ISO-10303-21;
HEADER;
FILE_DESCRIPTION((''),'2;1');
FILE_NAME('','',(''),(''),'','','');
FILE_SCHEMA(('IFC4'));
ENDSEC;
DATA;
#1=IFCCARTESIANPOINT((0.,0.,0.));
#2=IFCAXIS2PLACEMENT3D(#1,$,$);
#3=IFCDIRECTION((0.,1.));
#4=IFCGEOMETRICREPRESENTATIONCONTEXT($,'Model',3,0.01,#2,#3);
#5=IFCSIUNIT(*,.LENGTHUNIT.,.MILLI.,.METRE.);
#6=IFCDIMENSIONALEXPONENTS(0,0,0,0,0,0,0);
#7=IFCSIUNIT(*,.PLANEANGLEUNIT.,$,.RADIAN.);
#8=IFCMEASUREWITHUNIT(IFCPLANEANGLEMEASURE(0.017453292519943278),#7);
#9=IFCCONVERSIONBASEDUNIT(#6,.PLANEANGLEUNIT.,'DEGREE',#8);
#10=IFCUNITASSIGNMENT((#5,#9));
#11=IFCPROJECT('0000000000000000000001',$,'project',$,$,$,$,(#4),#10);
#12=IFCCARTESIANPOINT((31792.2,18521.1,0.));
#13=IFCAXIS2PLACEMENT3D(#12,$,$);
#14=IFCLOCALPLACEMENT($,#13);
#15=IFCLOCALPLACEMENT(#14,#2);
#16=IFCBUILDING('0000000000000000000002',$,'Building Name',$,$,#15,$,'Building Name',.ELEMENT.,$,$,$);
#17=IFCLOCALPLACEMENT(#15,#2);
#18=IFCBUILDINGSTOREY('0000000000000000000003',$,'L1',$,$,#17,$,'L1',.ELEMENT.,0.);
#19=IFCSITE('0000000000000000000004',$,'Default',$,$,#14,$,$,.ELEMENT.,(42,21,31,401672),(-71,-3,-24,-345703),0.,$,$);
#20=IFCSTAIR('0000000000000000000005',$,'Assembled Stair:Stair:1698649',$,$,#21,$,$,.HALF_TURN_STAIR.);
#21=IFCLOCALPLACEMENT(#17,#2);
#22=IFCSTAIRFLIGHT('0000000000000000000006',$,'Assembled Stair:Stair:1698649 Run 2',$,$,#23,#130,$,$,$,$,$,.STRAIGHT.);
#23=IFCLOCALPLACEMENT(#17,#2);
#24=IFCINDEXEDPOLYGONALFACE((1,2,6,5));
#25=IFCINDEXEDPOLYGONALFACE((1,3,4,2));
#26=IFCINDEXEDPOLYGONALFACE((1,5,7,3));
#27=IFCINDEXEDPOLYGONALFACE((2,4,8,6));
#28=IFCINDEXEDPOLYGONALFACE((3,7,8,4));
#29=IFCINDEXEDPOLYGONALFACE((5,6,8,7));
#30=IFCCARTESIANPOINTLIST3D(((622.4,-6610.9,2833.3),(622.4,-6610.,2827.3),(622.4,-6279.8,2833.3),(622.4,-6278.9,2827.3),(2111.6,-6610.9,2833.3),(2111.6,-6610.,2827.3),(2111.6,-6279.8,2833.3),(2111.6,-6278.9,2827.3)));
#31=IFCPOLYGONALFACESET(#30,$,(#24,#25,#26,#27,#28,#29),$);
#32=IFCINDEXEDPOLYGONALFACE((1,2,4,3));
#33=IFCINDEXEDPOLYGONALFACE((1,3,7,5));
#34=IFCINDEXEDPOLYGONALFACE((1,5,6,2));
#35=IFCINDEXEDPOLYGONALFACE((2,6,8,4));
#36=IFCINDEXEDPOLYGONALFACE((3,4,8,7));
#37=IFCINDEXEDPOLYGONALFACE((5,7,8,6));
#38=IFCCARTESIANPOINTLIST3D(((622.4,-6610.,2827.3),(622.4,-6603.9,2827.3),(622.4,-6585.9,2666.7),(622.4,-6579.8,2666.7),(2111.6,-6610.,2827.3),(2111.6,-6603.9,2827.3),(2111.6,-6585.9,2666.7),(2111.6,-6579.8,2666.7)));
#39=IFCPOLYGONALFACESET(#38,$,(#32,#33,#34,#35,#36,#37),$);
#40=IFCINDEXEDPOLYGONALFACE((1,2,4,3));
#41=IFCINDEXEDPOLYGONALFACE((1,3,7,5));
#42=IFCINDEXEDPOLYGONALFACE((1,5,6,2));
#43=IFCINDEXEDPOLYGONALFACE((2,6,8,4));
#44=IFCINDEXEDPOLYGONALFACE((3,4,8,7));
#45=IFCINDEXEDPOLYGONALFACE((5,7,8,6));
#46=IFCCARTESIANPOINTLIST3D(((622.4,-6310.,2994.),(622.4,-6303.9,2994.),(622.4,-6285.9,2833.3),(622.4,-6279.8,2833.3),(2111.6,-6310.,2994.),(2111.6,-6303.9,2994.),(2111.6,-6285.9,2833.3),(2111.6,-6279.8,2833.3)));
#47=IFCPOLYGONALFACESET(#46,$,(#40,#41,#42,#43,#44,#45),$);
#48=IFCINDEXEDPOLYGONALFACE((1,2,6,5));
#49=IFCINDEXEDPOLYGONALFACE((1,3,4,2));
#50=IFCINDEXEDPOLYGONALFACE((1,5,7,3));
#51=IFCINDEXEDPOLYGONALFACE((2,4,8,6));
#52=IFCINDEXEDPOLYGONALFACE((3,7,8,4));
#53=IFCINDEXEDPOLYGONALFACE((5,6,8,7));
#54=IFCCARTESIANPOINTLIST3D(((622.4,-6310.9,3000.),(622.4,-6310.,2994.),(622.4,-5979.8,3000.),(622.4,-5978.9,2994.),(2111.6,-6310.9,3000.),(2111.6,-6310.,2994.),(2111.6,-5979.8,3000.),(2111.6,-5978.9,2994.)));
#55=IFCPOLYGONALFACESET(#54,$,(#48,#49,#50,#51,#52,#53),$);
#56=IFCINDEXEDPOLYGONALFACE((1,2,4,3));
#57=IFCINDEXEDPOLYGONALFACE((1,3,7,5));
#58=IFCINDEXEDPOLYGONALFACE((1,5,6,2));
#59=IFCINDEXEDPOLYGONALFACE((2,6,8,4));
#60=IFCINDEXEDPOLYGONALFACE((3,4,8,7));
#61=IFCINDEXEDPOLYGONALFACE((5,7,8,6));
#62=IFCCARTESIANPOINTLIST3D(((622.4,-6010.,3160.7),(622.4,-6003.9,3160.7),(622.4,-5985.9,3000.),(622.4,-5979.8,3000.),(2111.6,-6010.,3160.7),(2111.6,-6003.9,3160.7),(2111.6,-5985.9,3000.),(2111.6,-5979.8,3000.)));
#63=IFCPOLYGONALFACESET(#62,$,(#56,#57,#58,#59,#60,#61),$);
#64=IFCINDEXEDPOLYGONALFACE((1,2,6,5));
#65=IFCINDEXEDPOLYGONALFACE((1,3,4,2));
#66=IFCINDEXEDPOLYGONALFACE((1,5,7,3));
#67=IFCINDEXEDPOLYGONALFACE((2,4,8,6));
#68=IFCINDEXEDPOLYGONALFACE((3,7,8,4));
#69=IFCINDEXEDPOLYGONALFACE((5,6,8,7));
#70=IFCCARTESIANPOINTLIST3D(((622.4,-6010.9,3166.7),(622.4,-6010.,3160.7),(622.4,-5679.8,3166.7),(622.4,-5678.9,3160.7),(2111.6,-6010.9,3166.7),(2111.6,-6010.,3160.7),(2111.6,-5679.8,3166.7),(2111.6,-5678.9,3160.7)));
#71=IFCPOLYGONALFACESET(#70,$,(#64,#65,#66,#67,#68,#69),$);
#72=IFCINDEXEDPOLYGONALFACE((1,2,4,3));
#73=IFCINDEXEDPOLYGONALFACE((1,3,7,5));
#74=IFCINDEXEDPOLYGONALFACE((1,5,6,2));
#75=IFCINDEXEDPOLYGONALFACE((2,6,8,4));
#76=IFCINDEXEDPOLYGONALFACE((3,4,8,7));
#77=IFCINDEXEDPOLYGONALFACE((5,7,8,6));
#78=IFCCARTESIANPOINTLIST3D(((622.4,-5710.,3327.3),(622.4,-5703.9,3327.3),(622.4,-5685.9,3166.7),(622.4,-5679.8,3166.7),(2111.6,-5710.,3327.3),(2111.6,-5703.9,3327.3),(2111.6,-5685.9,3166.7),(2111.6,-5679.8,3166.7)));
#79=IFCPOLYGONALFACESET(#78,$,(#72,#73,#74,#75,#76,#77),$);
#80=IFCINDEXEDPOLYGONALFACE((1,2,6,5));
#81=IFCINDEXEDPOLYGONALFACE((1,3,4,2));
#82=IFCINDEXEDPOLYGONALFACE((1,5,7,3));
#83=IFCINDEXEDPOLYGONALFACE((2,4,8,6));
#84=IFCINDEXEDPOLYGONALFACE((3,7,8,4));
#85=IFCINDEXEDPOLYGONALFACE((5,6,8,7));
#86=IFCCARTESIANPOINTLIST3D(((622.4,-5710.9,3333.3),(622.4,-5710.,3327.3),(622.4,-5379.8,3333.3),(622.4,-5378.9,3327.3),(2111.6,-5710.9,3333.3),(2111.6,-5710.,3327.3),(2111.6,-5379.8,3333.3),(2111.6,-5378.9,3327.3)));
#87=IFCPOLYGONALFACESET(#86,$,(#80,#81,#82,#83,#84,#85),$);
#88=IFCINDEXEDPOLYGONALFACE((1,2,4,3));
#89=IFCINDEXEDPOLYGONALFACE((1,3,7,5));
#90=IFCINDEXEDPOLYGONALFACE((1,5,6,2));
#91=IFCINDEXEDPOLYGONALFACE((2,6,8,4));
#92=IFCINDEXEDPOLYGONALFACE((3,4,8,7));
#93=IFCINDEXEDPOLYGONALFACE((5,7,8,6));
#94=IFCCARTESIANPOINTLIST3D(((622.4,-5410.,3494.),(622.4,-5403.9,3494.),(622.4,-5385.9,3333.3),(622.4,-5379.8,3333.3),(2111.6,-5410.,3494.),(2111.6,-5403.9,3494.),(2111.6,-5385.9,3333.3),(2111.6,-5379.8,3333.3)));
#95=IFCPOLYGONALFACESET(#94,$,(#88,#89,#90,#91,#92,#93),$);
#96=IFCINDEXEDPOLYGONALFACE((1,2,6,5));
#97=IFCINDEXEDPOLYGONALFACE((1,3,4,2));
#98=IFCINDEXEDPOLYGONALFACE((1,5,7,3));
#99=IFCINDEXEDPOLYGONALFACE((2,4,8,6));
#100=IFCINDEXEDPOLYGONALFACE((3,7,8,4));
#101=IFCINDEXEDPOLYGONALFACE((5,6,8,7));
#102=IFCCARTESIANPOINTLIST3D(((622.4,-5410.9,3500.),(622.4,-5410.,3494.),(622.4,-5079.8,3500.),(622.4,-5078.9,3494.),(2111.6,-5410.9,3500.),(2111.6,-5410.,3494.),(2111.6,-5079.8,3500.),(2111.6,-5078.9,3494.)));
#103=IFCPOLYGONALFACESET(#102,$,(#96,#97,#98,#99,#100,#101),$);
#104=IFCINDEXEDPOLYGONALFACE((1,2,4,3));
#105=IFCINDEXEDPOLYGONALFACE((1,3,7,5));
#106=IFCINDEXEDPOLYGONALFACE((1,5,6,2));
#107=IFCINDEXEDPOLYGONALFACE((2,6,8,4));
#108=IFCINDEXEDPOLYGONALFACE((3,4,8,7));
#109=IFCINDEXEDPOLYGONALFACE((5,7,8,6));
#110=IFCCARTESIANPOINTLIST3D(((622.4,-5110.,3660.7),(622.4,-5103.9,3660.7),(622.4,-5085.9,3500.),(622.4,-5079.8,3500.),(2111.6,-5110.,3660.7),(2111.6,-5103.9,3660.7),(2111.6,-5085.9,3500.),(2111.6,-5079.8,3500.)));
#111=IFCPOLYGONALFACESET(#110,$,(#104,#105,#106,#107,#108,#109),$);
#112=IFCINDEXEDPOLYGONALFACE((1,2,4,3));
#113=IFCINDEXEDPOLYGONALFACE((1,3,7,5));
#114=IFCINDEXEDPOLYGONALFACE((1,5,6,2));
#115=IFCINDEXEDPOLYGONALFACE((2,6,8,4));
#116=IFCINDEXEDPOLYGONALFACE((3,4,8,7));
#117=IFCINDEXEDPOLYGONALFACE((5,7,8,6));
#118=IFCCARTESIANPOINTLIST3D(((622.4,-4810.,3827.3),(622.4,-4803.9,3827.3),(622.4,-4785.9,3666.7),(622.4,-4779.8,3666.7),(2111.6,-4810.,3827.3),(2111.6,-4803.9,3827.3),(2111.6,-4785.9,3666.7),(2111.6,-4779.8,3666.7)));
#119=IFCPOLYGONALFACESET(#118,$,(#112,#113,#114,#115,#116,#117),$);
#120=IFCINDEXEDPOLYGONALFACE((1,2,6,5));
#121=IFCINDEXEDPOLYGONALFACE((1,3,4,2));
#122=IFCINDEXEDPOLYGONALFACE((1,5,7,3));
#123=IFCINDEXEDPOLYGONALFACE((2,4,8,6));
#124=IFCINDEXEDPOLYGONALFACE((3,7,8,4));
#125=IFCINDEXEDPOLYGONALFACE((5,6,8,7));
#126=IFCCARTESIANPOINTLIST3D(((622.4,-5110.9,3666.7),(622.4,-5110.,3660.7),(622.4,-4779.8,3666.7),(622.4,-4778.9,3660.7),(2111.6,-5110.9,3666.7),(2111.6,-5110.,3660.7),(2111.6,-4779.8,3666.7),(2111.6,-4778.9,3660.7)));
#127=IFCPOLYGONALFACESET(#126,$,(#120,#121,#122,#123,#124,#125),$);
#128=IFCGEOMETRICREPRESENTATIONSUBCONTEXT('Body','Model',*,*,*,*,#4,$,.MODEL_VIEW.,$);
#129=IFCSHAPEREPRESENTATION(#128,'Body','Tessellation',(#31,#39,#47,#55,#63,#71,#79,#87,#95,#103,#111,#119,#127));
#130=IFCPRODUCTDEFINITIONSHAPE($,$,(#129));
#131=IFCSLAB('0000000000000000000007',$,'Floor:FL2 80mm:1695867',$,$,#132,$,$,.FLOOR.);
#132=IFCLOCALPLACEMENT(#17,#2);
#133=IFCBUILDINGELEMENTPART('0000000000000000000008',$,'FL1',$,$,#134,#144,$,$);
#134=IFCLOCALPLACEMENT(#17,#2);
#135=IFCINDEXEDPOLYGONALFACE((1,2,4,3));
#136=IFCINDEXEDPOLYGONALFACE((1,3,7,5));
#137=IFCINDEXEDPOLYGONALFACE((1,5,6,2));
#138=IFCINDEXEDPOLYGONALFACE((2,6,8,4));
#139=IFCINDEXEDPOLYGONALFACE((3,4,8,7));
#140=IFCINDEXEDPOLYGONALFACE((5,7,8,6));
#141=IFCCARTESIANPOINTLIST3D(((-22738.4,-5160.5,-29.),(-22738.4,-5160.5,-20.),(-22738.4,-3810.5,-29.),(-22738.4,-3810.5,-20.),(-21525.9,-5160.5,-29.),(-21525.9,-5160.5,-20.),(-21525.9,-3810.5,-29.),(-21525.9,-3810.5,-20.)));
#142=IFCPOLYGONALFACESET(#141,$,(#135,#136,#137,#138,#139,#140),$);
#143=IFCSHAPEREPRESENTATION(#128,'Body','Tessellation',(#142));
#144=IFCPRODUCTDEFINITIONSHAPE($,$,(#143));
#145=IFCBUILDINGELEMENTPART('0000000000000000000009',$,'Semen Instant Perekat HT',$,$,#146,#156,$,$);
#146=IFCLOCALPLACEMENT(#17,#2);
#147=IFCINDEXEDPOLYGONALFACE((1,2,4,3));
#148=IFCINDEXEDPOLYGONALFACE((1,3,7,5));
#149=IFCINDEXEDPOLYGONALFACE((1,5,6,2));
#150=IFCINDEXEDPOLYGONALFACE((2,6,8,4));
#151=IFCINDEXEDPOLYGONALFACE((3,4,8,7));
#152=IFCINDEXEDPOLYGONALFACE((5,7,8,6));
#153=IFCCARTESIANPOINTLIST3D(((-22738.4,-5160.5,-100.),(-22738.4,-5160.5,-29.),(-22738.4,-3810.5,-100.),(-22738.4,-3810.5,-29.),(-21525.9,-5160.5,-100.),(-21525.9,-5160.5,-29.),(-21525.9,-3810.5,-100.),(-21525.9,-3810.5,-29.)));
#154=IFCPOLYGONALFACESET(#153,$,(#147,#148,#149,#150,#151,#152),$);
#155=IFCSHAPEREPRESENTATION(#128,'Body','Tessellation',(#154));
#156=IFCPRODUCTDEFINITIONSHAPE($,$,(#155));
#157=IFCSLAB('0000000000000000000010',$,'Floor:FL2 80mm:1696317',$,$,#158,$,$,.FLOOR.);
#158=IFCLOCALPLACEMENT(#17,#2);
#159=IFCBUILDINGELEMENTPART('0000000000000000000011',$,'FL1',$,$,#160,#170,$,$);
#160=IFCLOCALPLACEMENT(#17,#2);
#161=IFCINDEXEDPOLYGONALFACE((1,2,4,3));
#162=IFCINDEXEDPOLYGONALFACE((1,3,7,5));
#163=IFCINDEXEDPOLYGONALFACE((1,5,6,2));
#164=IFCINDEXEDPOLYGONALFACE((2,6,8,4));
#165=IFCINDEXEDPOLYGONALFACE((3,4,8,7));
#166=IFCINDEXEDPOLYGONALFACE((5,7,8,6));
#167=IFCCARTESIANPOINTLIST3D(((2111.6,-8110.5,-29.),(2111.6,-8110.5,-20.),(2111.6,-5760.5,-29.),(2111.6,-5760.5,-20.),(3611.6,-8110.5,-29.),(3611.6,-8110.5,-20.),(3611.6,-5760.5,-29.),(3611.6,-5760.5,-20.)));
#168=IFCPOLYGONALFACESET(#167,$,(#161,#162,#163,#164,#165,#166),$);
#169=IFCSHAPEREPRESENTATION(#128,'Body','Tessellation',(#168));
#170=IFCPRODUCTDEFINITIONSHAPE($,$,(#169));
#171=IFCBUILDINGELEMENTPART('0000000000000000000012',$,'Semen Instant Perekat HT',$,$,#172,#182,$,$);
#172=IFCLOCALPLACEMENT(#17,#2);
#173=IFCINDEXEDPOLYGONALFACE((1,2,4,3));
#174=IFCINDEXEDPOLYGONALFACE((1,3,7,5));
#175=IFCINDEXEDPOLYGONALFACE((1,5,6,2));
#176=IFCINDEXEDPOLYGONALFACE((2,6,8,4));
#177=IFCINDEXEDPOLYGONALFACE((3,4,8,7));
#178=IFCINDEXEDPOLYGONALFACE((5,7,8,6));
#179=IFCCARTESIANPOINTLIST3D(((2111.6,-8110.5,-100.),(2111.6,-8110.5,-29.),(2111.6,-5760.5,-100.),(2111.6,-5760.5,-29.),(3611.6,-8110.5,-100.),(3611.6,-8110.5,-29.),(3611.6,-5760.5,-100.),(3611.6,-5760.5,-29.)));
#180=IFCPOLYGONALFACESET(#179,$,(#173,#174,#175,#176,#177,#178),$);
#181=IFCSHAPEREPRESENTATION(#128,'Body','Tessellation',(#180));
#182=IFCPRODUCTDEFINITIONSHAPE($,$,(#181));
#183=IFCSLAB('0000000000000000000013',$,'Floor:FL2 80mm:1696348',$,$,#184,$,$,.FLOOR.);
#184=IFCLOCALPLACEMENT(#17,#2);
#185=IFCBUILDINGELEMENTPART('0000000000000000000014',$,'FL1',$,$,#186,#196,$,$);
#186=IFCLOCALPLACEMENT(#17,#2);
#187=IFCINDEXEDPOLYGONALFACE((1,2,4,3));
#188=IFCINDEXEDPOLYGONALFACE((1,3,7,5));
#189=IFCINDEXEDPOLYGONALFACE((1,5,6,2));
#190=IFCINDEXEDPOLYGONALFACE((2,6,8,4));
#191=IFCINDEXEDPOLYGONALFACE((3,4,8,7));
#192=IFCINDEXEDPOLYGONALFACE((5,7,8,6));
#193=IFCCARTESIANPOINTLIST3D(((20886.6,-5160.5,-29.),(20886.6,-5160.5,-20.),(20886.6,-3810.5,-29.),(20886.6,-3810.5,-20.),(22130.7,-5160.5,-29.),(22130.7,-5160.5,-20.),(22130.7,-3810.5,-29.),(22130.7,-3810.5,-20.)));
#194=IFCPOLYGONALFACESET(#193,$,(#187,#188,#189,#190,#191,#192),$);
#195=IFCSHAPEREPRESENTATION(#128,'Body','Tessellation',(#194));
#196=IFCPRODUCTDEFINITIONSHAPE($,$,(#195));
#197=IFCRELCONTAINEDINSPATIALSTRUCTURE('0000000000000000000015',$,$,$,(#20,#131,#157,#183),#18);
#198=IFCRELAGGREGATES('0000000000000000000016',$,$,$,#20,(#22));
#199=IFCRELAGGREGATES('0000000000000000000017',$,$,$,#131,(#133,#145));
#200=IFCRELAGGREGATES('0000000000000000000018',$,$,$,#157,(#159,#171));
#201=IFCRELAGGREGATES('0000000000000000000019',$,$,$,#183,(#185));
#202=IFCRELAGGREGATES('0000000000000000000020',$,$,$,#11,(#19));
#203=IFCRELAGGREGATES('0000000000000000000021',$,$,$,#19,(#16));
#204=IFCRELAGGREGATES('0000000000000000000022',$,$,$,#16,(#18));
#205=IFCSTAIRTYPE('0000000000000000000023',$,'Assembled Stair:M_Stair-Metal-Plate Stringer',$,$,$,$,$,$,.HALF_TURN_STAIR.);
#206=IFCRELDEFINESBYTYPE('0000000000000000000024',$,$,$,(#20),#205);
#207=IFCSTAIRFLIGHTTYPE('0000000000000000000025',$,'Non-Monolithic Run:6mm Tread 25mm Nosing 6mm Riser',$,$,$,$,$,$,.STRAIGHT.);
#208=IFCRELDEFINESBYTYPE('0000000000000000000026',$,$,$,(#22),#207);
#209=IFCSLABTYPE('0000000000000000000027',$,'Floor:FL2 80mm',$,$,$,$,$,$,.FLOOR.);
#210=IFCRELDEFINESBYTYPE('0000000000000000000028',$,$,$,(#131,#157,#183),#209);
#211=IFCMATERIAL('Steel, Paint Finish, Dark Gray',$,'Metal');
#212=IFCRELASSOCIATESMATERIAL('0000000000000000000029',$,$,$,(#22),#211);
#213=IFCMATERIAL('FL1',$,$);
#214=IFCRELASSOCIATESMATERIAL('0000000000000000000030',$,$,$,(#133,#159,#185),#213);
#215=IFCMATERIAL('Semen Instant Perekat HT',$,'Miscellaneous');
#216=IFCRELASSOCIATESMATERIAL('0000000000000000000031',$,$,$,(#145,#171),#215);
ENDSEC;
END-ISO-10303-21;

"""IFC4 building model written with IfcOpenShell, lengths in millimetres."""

from ifc_helpers import new_model, entity, si_unit, converted_unit, direction, frame, origin, place, context, subcontext, project, spatial, indexed_curve, outline, extrude, material, type_object, element, aggregate, save


model = new_model("IFC4")

# Units and contexts
model_context = context("Model", 3, precision=0.01, world=origin(), true_north=direction((0.0, 1.0)))
body_context = subcontext(model_context, "Body", "Model", "MODEL_VIEW")
ifc_project = project(units=[si_unit("LENGTHUNIT", "METRE", prefix="MILLI"), converted_unit("PLANEANGLEUNIT", "DEGREE", entity("IfcPlaneAngleMeasure", 0.017453292519943278), si_unit("PLANEANGLEUNIT", "RADIAN"), dimensions=[0, 0, 0, 0, 0, 0, 0])], contexts=[model_context])

# Site, building, storey
site_placement = place(None, frame((31792.2, 18521.1, 0.0)))
site = spatial("IfcSite", under=ifc_project, at=site_placement, Name="Default", CompositionType="ELEMENT", RefLatitude=(42, 21, 31, 401672), RefLongitude=(-71, -3, -24, -345703), RefElevation=0.0)
building_placement = place(site_placement, origin())
building = spatial("IfcBuilding", under=site, at=building_placement, Name="Building Name", LongName="Building Name", CompositionType="ELEMENT")
storey_placement = place(building_placement, origin())
storey = spatial("IfcBuildingStorey", under=building, at=storey_placement, Name="L1", LongName="L1", CompositionType="ELEMENT", Elevation=0.0)

# Stair
stair_type = type_object("IfcStairType", Name="Assembled Stair:M_Stair-Metal-Plate Stringer", PredefinedType="HALF_TURN_STAIR")
stair_placement = place(storey_placement, origin())
stair = element("IfcStair", 1, at=stair_placement, inside=storey, type_object=stair_type, Name="Assembled Stair:Stair:1698649", PredefinedType="HALF_TURN_STAIR")
ifc_material_1 = material(Name="Steel, Paint Finish, Dark Gray", Category="Metal")

# Stair flight
stair_flight_type = type_object("IfcStairFlightType", Name="Non-Monolithic Run:6mm Tread 25mm Nosing 6mm Riser", PredefinedType="STRAIGHT")
stair_flight_placement = place(stair_placement, origin())
stair_flight = element("IfcStairFlight", 2, at=stair_flight_placement, type_object=stair_flight_type, material=ifc_material_1, Name="Assembled Stair:Stair:1698649 Run 2", PredefinedType="STRAIGHT", context=body_context, shape_type="SweptSolid", body=[
    extrude(outline(indexed_curve([(-27.6, -163.7), (-21.5, -163.7), (27.6, 163.7), (21.5, 163.7), (-27.6, -163.7)], self_intersect=False)), frame((622.4, -6444.9, 2830.3), z_axis=(1.0, 0.0, 0.0), x_axis=(0.0, 0.14834, -0.988936)), (0.0, 0.0, 1.0), 1489.2),
    extrude(outline(indexed_curve([(-81.7, -3.0), (80.8, -3.0), (81.7, 3.0), (-80.8, 3.0), (-81.7, -3.0)], self_intersect=False)), frame((622.4, -6594.9, 2747.0), z_axis=(1.0, 0.0, 0.0), x_axis=(0.0, 0.14834, -0.988936)), (0.0, 0.0, 1.0), 1489.2),
    extrude(outline(indexed_curve([(-81.7, -3.0), (80.8, -3.0), (81.7, 3.0), (-80.8, 3.0), (-81.7, -3.0)], self_intersect=False)), frame((622.4, -6294.9, 2913.7), z_axis=(1.0, 0.0, 0.0), x_axis=(0.0, 0.14834, -0.988936)), (0.0, 0.0, 1.0), 1489.2),
    extrude(outline(indexed_curve([(-27.6, -163.7), (-21.5, -163.7), (27.6, 163.7), (21.5, 163.7), (-27.6, -163.7)], self_intersect=False)), frame((622.4, -6144.9, 2997.0), z_axis=(1.0, 0.0, 0.0), x_axis=(0.0, 0.14834, -0.988936)), (0.0, 0.0, 1.0), 1489.2),
    extrude(outline(indexed_curve([(-81.7, -3.0), (80.8, -3.0), (81.7, 3.0), (-80.8, 3.0), (-81.7, -3.0)], self_intersect=False)), frame((622.4, -5994.9, 3080.3), z_axis=(1.0, 0.0, 0.0), x_axis=(0.0, 0.14834, -0.988936)), (0.0, 0.0, 1.0), 1489.2),
    extrude(outline(indexed_curve([(-27.6, -163.7), (-21.5, -163.7), (27.6, 163.7), (21.5, 163.7), (-27.6, -163.7)], self_intersect=False)), frame((622.4, -5844.9, 3163.7), z_axis=(1.0, 0.0, 0.0), x_axis=(0.0, 0.14834, -0.988936)), (0.0, 0.0, 1.0), 1489.2),
    extrude(outline(indexed_curve([(-81.7, -3.0), (80.8, -3.0), (81.7, 3.0), (-80.8, 3.0), (-81.7, -3.0)], self_intersect=False)), frame((622.4, -5694.9, 3247.0), z_axis=(1.0, 0.0, 0.0), x_axis=(0.0, 0.14834, -0.988936)), (0.0, 0.0, 1.0), 1489.2),
    extrude(outline(indexed_curve([(-27.6, -163.7), (-21.5, -163.7), (27.6, 163.7), (21.5, 163.7), (-27.6, -163.7)], self_intersect=False)), frame((622.4, -5544.9, 3330.3), z_axis=(1.0, 0.0, 0.0), x_axis=(0.0, 0.14834, -0.988936)), (0.0, 0.0, 1.0), 1489.2),
    extrude(outline(indexed_curve([(-81.7, -3.0), (80.8, -3.0), (81.7, 3.0), (-80.8, 3.0), (-81.7, -3.0)], self_intersect=False)), frame((622.4, -5394.9, 3413.7), z_axis=(1.0, 0.0, 0.0), x_axis=(0.0, 0.14834, -0.988936)), (0.0, 0.0, 1.0), 1489.2),
    extrude(outline(indexed_curve([(-27.6, -163.7), (-21.5, -163.7), (27.6, 163.7), (21.5, 163.7), (-27.6, -163.7)], self_intersect=False)), frame((622.4, -5244.9, 3497.0), z_axis=(1.0, 0.0, 0.0), x_axis=(0.0, 0.14834, -0.988936)), (0.0, 0.0, 1.0), 1489.2),
    extrude(outline(indexed_curve([(-81.7, -3.0), (80.8, -3.0), (81.7, 3.0), (-80.8, 3.0), (-81.7, -3.0)], self_intersect=False)), frame((622.4, -5094.9, 3580.3), z_axis=(1.0, 0.0, 0.0), x_axis=(0.0, 0.14834, -0.988936)), (0.0, 0.0, 1.0), 1489.2),
    extrude(outline(indexed_curve([(-81.7, -3.0), (80.8, -3.0), (81.7, 3.0), (-80.8, 3.0), (-81.7, -3.0)], self_intersect=False)), frame((622.4, -4794.9, 3747.0), z_axis=(1.0, 0.0, 0.0), x_axis=(0.0, 0.14834, -0.988936)), (0.0, 0.0, 1.0), 1489.2),
    extrude(outline(indexed_curve([(-27.6, -163.7), (-21.5, -163.7), (27.6, 163.7), (21.5, 163.7), (-27.6, -163.7)], self_intersect=False)), frame((622.4, -4944.9, 3663.7), z_axis=(1.0, 0.0, 0.0), x_axis=(0.0, 0.14834, -0.988936)), (0.0, 0.0, 1.0), 1489.2),
])
aggregate(stair, [stair_flight])

# Shared definitions
ifc_material_2 = material(Name="Semen Instant Perekat HT", Category="Miscellaneous")

# Slabs, building element parts
slab_type_1 = type_object("IfcSlabType", Name="Floor:FL2 80mm", PredefinedType="FLOOR")
slab_1_placement = place(storey_placement, origin())
slab_1 = element("IfcSlab", 3, at=slab_1_placement, inside=storey, type_object=slab_type_1, Name="Floor:FL2 80mm:1695867", PredefinedType="FLOOR")
ifc_material_3 = material(Name="FL1")
building_element_part_1_placement = place(slab_1_placement, origin())
building_element_part_1 = element("IfcBuildingElementPart", 4, at=building_element_part_1_placement, material=ifc_material_3, Name="FL1", context=body_context, shape_type="SweptSolid", body=[
    extrude(outline(indexed_curve([(-675.0, -606.2), (675.0, -606.2), (675.0, 606.2), (-675.0, 606.2), (-675.0, -606.2)], self_intersect=False)), frame((-22132.1, -4485.5, -29.0), z_axis=(0.0, 0.0, 1.0), x_axis=(0.0, -1.0, 0.0)), (0.0, 0.0, 1.0), 9.0),
])
building_element_part_2_placement = place(slab_1_placement, origin())
building_element_part_2 = element("IfcBuildingElementPart", 5, at=building_element_part_2_placement, material=ifc_material_2, Name="Semen Instant Perekat HT", context=body_context, shape_type="SweptSolid", body=[
    extrude(outline(indexed_curve([(-675.0, -606.2), (675.0, -606.2), (675.0, 606.2), (-675.0, 606.2), (-675.0, -606.2)], self_intersect=False)), frame((-22132.1, -4485.5, -100.0), z_axis=(0.0, 0.0, 1.0), x_axis=(0.0, -1.0, 0.0)), (0.0, 0.0, 1.0), 71.0),
])
aggregate(slab_1, [building_element_part_1, building_element_part_2])
slab_2_placement = place(storey_placement, origin())
slab_2 = element("IfcSlab", 6, at=slab_2_placement, inside=storey, type_object=slab_type_1, Name="Floor:FL2 80mm:1696317", PredefinedType="FLOOR")
building_element_part_3_placement = place(slab_2_placement, origin())
building_element_part_3 = element("IfcBuildingElementPart", 7, at=building_element_part_3_placement, material=ifc_material_3, Name="FL1", context=body_context, shape_type="SweptSolid", body=[
    extrude(outline(indexed_curve([(-1175.0, -750.0), (1175.0, -750.0), (1175.0, 750.0), (-1175.0, 750.0), (-1175.0, -750.0)], self_intersect=False)), frame((2861.6, -6935.5, -29.0), z_axis=(0.0, 0.0, 1.0), x_axis=(0.0, -1.0, 0.0)), (0.0, 0.0, 1.0), 9.0),
])
building_element_part_4_placement = place(slab_2_placement, origin())
building_element_part_4 = element("IfcBuildingElementPart", 8, at=building_element_part_4_placement, material=ifc_material_2, Name="Semen Instant Perekat HT", context=body_context, shape_type="SweptSolid", body=[
    extrude(outline(indexed_curve([(-1175.0, -750.0), (1175.0, -750.0), (1175.0, 750.0), (-1175.0, 750.0), (-1175.0, -750.0)], self_intersect=False)), frame((2861.6, -6935.5, -100.0), z_axis=(0.0, 0.0, 1.0), x_axis=(0.0, -1.0, 0.0)), (0.0, 0.0, 1.0), 71.0),
])
aggregate(slab_2, [building_element_part_3, building_element_part_4])
slab_3_placement = place(storey_placement, origin())
slab_3 = element("IfcSlab", 9, at=slab_3_placement, inside=storey, type_object=slab_type_1, Name="Floor:FL2 80mm:1696348", PredefinedType="FLOOR")
building_element_part_5_placement = place(slab_3_placement, origin())
building_element_part_5 = element("IfcBuildingElementPart", 10, at=building_element_part_5_placement, material=ifc_material_3, Name="FL1", context=body_context, shape_type="SweptSolid", body=[
    extrude(outline(indexed_curve([(-675.0, -622.0), (675.0, -622.0), (675.0, 622.0), (-675.0, 622.0), (-675.0, -622.0)], self_intersect=False)), frame((21508.7, -4485.5, -29.0), z_axis=(0.0, 0.0, 1.0), x_axis=(0.0, -1.0, 0.0)), (0.0, 0.0, 1.0), 9.0),
])
aggregate(slab_3, [building_element_part_5])

save(model, "model.ifc")
